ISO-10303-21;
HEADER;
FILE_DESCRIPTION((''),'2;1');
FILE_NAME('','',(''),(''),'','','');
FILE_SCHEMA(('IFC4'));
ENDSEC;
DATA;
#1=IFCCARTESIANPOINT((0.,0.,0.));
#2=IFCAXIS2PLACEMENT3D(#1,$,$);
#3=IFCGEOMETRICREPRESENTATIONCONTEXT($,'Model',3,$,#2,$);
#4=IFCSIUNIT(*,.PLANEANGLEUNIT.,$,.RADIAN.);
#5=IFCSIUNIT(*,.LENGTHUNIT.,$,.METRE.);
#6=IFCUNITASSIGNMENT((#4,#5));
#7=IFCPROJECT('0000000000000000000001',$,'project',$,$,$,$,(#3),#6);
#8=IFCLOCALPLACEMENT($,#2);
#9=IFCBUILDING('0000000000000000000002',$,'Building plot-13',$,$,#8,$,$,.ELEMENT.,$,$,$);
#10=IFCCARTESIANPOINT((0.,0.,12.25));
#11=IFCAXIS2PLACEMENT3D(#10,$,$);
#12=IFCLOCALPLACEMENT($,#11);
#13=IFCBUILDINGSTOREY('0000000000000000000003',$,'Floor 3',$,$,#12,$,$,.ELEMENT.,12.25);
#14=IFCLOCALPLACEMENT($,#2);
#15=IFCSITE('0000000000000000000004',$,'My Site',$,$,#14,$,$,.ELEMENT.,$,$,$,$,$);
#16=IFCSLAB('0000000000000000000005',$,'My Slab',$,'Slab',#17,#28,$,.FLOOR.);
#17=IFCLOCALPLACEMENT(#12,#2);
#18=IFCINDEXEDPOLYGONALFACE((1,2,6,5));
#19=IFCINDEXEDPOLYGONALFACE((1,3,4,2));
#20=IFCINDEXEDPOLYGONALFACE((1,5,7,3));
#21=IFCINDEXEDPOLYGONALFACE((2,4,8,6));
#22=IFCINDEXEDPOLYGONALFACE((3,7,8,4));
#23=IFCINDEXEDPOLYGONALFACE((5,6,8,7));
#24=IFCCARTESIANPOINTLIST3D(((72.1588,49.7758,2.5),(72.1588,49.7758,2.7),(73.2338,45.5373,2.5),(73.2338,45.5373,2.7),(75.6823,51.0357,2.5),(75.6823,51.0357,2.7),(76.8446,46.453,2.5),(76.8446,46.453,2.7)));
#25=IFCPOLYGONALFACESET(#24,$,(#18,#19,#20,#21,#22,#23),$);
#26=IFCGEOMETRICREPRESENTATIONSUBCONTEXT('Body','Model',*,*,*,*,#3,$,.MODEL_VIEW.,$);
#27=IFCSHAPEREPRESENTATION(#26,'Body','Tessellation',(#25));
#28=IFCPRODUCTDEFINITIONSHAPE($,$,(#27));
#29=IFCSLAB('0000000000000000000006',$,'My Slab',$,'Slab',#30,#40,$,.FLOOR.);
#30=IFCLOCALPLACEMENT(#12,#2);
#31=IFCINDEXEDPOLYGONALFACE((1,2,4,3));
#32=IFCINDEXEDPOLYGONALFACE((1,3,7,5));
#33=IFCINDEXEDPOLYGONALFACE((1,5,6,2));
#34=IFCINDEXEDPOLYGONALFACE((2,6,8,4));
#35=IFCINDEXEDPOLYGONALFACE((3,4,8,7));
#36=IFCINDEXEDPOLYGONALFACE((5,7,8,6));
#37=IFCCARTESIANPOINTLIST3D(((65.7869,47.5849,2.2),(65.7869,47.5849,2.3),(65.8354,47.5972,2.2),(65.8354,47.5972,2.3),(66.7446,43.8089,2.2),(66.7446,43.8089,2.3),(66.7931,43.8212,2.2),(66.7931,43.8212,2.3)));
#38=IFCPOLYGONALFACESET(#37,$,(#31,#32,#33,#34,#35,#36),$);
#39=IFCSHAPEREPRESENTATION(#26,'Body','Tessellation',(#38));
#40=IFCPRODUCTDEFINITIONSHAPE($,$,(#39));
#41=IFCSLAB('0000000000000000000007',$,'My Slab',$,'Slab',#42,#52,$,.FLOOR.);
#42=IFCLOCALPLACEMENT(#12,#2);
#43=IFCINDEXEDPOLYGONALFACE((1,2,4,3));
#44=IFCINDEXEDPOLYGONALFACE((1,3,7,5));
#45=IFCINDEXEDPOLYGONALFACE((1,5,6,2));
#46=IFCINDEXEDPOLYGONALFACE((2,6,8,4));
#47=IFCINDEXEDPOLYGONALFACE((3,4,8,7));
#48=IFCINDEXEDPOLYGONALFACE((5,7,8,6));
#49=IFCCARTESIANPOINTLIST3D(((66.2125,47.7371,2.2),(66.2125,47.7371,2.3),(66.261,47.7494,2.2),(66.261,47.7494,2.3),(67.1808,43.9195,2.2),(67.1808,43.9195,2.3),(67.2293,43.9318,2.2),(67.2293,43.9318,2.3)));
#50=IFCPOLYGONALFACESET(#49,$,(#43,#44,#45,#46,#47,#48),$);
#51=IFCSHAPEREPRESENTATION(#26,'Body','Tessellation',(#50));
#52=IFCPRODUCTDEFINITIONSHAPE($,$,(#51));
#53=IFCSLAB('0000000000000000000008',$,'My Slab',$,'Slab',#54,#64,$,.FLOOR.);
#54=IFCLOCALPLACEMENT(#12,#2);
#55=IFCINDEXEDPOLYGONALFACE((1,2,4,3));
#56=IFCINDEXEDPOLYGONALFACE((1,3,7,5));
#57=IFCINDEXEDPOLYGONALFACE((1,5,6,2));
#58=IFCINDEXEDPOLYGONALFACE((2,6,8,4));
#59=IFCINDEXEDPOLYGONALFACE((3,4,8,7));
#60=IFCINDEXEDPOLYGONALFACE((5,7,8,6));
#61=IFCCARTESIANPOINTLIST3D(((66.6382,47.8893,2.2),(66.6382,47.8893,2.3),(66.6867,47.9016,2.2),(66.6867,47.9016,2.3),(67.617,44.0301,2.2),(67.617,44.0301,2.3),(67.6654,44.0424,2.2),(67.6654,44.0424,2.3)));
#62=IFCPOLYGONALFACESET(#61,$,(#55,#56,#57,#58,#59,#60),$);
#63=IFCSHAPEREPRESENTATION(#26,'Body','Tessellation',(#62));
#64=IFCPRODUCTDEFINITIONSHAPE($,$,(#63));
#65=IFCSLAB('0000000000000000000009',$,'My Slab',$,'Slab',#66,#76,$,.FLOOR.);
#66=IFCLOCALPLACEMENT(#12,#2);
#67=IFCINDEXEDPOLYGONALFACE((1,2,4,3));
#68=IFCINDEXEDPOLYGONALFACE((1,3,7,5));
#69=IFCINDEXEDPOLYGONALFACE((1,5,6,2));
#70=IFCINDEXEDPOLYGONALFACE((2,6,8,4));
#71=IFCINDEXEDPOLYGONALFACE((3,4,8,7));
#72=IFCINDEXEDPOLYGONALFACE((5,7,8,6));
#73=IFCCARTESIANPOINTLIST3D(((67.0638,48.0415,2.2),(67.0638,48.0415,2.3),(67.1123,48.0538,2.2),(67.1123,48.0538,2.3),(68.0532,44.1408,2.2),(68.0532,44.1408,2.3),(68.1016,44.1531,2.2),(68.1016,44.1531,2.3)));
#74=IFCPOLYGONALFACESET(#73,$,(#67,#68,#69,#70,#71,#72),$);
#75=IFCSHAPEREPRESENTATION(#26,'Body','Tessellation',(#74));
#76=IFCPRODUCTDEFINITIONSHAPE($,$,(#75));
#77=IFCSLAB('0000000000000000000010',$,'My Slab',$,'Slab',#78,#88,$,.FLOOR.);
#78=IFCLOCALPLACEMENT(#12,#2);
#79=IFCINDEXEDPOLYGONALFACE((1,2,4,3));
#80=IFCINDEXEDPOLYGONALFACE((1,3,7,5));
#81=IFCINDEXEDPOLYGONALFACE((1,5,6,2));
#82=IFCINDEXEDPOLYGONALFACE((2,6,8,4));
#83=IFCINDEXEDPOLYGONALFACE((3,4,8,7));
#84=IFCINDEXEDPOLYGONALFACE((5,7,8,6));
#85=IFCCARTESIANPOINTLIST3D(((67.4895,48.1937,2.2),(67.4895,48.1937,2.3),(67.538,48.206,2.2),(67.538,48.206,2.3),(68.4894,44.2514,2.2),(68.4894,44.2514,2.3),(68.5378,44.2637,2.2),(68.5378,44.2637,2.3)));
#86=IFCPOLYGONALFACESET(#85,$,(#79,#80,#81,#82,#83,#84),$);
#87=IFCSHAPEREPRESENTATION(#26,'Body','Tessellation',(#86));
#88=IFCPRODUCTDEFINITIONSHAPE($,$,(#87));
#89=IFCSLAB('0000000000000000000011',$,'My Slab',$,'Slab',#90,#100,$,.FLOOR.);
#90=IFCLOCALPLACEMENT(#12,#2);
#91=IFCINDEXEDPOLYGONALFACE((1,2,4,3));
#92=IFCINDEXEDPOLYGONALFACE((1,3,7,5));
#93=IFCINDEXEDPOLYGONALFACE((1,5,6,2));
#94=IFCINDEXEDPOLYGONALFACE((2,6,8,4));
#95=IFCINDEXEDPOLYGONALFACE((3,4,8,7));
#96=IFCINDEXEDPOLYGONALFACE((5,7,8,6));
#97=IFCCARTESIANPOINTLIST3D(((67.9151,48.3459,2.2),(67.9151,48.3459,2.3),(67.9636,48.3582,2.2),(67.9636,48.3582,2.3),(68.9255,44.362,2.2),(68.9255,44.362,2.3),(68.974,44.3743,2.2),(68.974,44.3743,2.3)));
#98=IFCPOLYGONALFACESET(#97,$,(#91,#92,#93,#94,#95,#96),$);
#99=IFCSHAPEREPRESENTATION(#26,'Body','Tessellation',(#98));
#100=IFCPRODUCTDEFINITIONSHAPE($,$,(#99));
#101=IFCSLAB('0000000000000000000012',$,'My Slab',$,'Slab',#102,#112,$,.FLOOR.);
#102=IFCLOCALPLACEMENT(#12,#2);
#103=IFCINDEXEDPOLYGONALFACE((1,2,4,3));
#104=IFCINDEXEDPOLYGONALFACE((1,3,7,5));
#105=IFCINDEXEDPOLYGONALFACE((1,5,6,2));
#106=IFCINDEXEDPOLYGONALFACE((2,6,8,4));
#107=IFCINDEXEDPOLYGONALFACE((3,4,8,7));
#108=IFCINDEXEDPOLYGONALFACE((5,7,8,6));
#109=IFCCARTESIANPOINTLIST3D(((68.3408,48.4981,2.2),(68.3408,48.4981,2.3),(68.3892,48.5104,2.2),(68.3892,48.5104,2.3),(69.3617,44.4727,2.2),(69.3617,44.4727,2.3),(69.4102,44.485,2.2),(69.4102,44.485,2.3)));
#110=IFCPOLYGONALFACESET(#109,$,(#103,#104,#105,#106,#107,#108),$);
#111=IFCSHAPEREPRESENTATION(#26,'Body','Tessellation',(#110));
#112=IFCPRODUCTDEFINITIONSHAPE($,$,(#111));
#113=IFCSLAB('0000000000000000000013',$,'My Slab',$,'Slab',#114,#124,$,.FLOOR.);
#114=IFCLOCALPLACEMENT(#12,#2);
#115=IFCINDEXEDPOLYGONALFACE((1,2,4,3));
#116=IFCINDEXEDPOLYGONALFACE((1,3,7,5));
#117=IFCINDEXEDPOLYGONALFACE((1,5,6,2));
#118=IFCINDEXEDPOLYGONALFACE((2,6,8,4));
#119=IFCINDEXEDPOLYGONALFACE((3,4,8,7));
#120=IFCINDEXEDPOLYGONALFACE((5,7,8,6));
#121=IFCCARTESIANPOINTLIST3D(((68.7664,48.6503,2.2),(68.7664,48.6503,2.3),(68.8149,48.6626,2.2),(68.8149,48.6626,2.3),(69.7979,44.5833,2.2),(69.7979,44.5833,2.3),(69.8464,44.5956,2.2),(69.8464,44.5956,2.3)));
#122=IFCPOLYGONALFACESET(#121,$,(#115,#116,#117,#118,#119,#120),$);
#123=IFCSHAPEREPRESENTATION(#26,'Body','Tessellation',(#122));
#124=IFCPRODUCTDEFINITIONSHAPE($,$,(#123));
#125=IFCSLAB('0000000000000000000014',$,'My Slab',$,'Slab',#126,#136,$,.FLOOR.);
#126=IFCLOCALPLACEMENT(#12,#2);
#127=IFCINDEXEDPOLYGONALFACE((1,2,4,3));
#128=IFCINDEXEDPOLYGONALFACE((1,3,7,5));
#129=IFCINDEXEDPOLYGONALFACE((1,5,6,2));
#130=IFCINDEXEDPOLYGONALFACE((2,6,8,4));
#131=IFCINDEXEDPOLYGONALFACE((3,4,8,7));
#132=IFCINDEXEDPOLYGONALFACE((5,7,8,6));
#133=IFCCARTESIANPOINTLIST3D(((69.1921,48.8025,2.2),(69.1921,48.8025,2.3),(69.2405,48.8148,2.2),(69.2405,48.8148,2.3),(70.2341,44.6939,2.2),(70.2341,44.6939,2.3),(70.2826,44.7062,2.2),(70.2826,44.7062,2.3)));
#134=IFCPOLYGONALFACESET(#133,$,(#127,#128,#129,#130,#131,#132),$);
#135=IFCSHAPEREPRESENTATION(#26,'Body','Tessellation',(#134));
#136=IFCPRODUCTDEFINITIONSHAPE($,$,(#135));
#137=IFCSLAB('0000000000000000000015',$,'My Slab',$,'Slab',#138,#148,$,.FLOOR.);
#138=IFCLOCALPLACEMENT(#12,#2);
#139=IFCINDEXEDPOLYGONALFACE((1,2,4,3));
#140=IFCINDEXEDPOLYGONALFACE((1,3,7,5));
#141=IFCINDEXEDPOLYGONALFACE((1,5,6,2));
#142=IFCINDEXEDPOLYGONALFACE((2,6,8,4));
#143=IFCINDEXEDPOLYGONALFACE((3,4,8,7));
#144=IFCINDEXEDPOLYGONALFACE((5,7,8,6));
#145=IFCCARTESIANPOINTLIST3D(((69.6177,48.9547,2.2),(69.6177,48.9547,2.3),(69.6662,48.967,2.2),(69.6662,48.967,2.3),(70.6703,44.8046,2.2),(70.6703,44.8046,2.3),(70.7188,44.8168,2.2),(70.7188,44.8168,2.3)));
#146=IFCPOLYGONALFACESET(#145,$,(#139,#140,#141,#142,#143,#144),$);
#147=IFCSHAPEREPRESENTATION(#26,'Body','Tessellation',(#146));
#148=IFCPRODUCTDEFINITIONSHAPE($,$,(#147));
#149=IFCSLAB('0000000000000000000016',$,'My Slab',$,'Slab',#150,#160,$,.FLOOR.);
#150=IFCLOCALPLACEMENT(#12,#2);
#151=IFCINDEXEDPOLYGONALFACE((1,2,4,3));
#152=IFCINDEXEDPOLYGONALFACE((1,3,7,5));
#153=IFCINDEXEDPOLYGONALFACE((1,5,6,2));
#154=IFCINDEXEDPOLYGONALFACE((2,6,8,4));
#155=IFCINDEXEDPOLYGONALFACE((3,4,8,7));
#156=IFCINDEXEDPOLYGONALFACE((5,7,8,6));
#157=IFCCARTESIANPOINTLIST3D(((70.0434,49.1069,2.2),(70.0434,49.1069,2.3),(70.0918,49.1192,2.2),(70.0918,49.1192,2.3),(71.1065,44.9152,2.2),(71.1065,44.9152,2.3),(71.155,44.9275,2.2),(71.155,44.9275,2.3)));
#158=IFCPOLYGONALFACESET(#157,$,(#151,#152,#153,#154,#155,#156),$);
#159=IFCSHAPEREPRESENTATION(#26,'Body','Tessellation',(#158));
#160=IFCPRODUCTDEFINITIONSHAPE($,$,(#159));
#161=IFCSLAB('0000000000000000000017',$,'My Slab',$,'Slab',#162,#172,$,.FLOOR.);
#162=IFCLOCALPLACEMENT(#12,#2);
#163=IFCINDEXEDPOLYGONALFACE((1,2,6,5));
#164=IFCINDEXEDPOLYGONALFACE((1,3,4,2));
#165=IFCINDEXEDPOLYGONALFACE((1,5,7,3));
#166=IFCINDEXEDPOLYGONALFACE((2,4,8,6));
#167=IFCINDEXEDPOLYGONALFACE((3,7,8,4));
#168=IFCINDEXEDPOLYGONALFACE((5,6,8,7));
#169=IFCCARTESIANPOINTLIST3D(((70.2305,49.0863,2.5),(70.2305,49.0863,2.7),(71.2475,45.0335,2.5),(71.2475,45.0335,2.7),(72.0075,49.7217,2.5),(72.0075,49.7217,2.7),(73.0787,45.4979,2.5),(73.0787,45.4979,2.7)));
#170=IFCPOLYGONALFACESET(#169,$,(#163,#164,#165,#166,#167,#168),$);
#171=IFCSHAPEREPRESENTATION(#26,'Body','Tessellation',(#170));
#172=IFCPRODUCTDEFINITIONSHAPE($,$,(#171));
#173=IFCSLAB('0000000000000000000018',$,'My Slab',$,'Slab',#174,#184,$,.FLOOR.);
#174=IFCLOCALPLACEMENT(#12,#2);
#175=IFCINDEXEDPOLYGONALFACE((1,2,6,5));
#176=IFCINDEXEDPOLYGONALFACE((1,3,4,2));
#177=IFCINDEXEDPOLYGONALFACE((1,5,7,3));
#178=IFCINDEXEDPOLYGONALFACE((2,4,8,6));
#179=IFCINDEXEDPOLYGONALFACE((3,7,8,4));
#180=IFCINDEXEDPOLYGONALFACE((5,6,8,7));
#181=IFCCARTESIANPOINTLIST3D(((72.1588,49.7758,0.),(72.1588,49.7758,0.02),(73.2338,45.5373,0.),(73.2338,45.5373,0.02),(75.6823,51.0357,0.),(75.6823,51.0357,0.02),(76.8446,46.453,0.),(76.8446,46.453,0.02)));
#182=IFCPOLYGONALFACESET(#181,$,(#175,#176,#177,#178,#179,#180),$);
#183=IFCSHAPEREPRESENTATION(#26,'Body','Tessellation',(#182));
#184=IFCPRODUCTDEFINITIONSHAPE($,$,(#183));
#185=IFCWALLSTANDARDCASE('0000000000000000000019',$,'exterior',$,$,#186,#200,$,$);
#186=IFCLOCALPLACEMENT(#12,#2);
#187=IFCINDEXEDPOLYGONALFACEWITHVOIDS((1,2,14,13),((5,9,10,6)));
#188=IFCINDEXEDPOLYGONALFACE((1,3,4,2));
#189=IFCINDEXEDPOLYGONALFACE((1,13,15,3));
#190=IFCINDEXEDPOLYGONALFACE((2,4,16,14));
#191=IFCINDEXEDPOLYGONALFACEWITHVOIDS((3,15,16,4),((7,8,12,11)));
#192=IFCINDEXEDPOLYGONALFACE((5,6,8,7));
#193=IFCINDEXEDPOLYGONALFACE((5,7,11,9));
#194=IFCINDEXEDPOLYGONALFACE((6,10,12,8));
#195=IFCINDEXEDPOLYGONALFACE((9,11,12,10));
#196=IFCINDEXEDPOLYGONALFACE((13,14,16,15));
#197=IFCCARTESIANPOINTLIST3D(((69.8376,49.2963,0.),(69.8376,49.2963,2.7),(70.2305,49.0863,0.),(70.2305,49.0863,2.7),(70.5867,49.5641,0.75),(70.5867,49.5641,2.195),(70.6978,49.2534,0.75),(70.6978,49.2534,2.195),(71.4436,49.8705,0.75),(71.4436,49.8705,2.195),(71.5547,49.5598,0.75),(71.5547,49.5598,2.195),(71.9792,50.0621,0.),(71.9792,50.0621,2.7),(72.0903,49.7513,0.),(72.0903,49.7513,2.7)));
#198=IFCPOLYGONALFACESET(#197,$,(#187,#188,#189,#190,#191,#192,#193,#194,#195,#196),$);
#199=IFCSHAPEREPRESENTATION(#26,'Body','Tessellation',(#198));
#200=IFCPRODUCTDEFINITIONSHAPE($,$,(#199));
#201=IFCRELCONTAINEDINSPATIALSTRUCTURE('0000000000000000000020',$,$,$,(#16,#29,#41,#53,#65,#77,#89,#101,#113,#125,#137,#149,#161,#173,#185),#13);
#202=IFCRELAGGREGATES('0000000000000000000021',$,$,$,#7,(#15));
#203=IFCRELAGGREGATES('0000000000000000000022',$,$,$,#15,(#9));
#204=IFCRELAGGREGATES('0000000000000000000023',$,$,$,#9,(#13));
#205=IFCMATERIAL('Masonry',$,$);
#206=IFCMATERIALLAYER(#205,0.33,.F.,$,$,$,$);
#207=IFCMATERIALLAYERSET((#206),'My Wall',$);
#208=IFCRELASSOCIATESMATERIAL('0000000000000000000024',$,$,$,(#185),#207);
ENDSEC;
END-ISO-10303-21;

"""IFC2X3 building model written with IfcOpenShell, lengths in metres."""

from ifc_helpers import new_model, si_unit, frame, origin, place, context, subcontext, project, spatial, polyline, outline, extrude, material, layer, layer_set, layer_usage, element, save


model = new_model("IFC2X3")

# Units and contexts
model_context = context("Model", 3, world=origin())
body_context = subcontext(model_context, "Body", "Model", "MODEL_VIEW")
ifc_project = project(units=[si_unit("PLANEANGLEUNIT", "RADIAN"), si_unit("LENGTHUNIT", "METRE")], contexts=[model_context])

# Site, building, storey
site_placement = place(None, origin())
site = spatial("IfcSite", under=ifc_project, at=site_placement, Name="My Site", CompositionType="ELEMENT")
building_placement = place(None, origin())
building = spatial("IfcBuilding", under=site, at=building_placement, Name="Building plot-13", CompositionType="ELEMENT")
storey_placement = place(None, frame((0.0, 0.0, 12.25)))
storey = spatial("IfcBuildingStorey", under=building, at=storey_placement, Name="Floor 3", CompositionType="ELEMENT", Elevation=12.25)

# Slabs
slab_1_placement = place(storey_placement, frame((0.0, 0.0, 2.5)))
element("IfcSlab", 1, at=slab_1_placement, inside=storey, Name="My Slab", ObjectType="Slab", PredefinedType="FLOOR", context=body_context, shape_type="SweptSolid", body=[
    extrude(outline(polyline([(72.1588, 49.7758), (73.2338, 45.5373), (76.8446, 46.453), (75.6823, 51.0357), (72.1588, 49.7758)])), origin(), (0.0, 0.0, 1.0), 0.2),
])
slab_2_placement = place(storey_placement, frame((0.0, 0.0, 2.2)))
element("IfcSlab", 2, at=slab_2_placement, inside=storey, Name="My Slab", ObjectType="Slab", PredefinedType="FLOOR", context=body_context, shape_type="SweptSolid", body=[
    extrude(outline(polyline([(66.7446, 43.8089), (66.7931, 43.8212), (65.8354, 47.5972), (65.7869, 47.5849), (66.7446, 43.8089)])), origin(), (0.0, 0.0, 1.0), 0.1),
])
slab_3_placement = place(storey_placement, frame((0.0, 0.0, 2.2)))
element("IfcSlab", 3, at=slab_3_placement, inside=storey, Name="My Slab", ObjectType="Slab", PredefinedType="FLOOR", context=body_context, shape_type="SweptSolid", body=[
    extrude(outline(polyline([(67.1808, 43.9195), (67.2293, 43.9318), (66.261, 47.7494), (66.2125, 47.7371), (67.1808, 43.9195)])), origin(), (0.0, 0.0, 1.0), 0.1),
])
slab_4_placement = place(storey_placement, frame((0.0, 0.0, 2.2)))
element("IfcSlab", 4, at=slab_4_placement, inside=storey, Name="My Slab", ObjectType="Slab", PredefinedType="FLOOR", context=body_context, shape_type="SweptSolid", body=[
    extrude(outline(polyline([(67.617, 44.0301), (67.6654, 44.0424), (66.6867, 47.9016), (66.6382, 47.8893), (67.617, 44.0301)])), origin(), (0.0, 0.0, 1.0), 0.1),
])
slab_5_placement = place(storey_placement, frame((0.0, 0.0, 2.2)))
element("IfcSlab", 5, at=slab_5_placement, inside=storey, Name="My Slab", ObjectType="Slab", PredefinedType="FLOOR", context=body_context, shape_type="SweptSolid", body=[
    extrude(outline(polyline([(68.0532, 44.1408), (68.1016, 44.1531), (67.1123, 48.0538), (67.0638, 48.0415), (68.0532, 44.1408)])), origin(), (0.0, 0.0, 1.0), 0.1),
])
slab_6_placement = place(storey_placement, frame((0.0, 0.0, 2.2)))
element("IfcSlab", 6, at=slab_6_placement, inside=storey, Name="My Slab", ObjectType="Slab", PredefinedType="FLOOR", context=body_context, shape_type="SweptSolid", body=[
    extrude(outline(polyline([(68.4894, 44.2514), (68.5378, 44.2637), (67.538, 48.206), (67.4895, 48.1937), (68.4894, 44.2514)])), origin(), (0.0, 0.0, 1.0), 0.1),
])
slab_7_placement = place(storey_placement, frame((0.0, 0.0, 2.2)))
element("IfcSlab", 7, at=slab_7_placement, inside=storey, Name="My Slab", ObjectType="Slab", PredefinedType="FLOOR", context=body_context, shape_type="SweptSolid", body=[
    extrude(outline(polyline([(68.9255, 44.362), (68.974, 44.3743), (67.9636, 48.3582), (67.9151, 48.3459), (68.9255, 44.362)])), origin(), (0.0, 0.0, 1.0), 0.1),
])
slab_8_placement = place(storey_placement, frame((0.0, 0.0, 2.2)))
element("IfcSlab", 8, at=slab_8_placement, inside=storey, Name="My Slab", ObjectType="Slab", PredefinedType="FLOOR", context=body_context, shape_type="SweptSolid", body=[
    extrude(outline(polyline([(69.3617, 44.4727), (69.4102, 44.485), (68.3892, 48.5104), (68.3408, 48.4981), (69.3617, 44.4727)])), origin(), (0.0, 0.0, 1.0), 0.1),
])
slab_9_placement = place(storey_placement, frame((0.0, 0.0, 2.2)))
element("IfcSlab", 9, at=slab_9_placement, inside=storey, Name="My Slab", ObjectType="Slab", PredefinedType="FLOOR", context=body_context, shape_type="SweptSolid", body=[
    extrude(outline(polyline([(69.7979, 44.5833), (69.8464, 44.5956), (68.8149, 48.6626), (68.7664, 48.6503), (69.7979, 44.5833)])), origin(), (0.0, 0.0, 1.0), 0.1),
])
slab_10_placement = place(storey_placement, frame((0.0, 0.0, 2.2)))
element("IfcSlab", 10, at=slab_10_placement, inside=storey, Name="My Slab", ObjectType="Slab", PredefinedType="FLOOR", context=body_context, shape_type="SweptSolid", body=[
    extrude(outline(polyline([(70.2341, 44.6939), (70.2826, 44.7062), (69.2405, 48.8148), (69.1921, 48.8025), (70.2341, 44.6939)])), origin(), (0.0, 0.0, 1.0), 0.1),
])
slab_11_placement = place(storey_placement, frame((0.0, 0.0, 2.2)))
element("IfcSlab", 11, at=slab_11_placement, inside=storey, Name="My Slab", ObjectType="Slab", PredefinedType="FLOOR", context=body_context, shape_type="SweptSolid", body=[
    extrude(outline(polyline([(70.6703, 44.8046), (70.7188, 44.8168), (69.6662, 48.967), (69.6177, 48.9547), (70.6703, 44.8046)])), origin(), (0.0, 0.0, 1.0), 0.1),
])
slab_12_placement = place(storey_placement, frame((0.0, 0.0, 2.2)))
element("IfcSlab", 12, at=slab_12_placement, inside=storey, Name="My Slab", ObjectType="Slab", PredefinedType="FLOOR", context=body_context, shape_type="SweptSolid", body=[
    extrude(outline(polyline([(71.1065, 44.9152), (71.155, 44.9275), (70.0918, 49.1192), (70.0434, 49.1069), (71.1065, 44.9152)])), origin(), (0.0, 0.0, 1.0), 0.1),
])
slab_13_placement = place(storey_placement, frame((0.0, 0.0, 2.5)))
element("IfcSlab", 13, at=slab_13_placement, inside=storey, Name="My Slab", ObjectType="Slab", PredefinedType="FLOOR", context=body_context, shape_type="SweptSolid", body=[
    extrude(outline(polyline([(70.2305, 49.0863), (71.2475, 45.0335), (73.0787, 45.4979), (72.0075, 49.7217), (70.2305, 49.0863)])), origin(), (0.0, 0.0, 1.0), 0.2),
])
slab_14_placement = place(storey_placement, origin())
element("IfcSlab", 14, at=slab_14_placement, inside=storey, Name="My Slab", ObjectType="Slab", PredefinedType="FLOOR", context=body_context, shape_type="SweptSolid", body=[
    extrude(outline(polyline([(72.1588, 49.7758), (73.2338, 45.5373), (76.8446, 46.453), (75.6823, 51.0357), (72.1588, 49.7758)])), origin(), (0.0, 0.0, 1.0), 0.02),
])

# Wall, opening
ifc_material_1 = material(Name="Masonry")
ifc_layer_1 = layer(ifc_material_1, 0.33, ventilated=False)
ifc_layer_set_1 = layer_set([ifc_layer_1], Name="My Wall")
ifc_layer_usage_1 = layer_usage(ifc_layer_set_1, "AXIS2", "NEGATIVE", 0.08)
wall_1_placement = place(storey_placement, origin())
wall_1 = element("IfcWallStandardCase", 15, at=wall_1_placement, inside=storey, material=ifc_layer_usage_1, Name="exterior", context=body_context, shape_type="SweptSolid", body=[
    extrude(outline(polyline([(72.0903, 49.7513), (71.9792, 50.0621), (69.8376, 49.2963), (70.2305, 49.0863), (72.0903, 49.7513)])), origin(), (0.0, 0.0, 1.0), 2.7),
])
opening_1_placement = place(storey_placement, frame((0.0, 0.0, 0.75)))
element("IfcOpeningElement", 16, at=opening_1_placement, cuts=wall_1, ObjectType="Opening", context=body_context, shape_type="SweptSolid", body=[
    extrude(outline(polyline([(71.4436, 49.8705), (70.5867, 49.5641), (70.6978, 49.2534), (71.5547, 49.5598), (71.4436, 49.8705)])), origin(), (0.0, 0.0, 1.0), 1.445),
])

save(model, "model.ifc")
